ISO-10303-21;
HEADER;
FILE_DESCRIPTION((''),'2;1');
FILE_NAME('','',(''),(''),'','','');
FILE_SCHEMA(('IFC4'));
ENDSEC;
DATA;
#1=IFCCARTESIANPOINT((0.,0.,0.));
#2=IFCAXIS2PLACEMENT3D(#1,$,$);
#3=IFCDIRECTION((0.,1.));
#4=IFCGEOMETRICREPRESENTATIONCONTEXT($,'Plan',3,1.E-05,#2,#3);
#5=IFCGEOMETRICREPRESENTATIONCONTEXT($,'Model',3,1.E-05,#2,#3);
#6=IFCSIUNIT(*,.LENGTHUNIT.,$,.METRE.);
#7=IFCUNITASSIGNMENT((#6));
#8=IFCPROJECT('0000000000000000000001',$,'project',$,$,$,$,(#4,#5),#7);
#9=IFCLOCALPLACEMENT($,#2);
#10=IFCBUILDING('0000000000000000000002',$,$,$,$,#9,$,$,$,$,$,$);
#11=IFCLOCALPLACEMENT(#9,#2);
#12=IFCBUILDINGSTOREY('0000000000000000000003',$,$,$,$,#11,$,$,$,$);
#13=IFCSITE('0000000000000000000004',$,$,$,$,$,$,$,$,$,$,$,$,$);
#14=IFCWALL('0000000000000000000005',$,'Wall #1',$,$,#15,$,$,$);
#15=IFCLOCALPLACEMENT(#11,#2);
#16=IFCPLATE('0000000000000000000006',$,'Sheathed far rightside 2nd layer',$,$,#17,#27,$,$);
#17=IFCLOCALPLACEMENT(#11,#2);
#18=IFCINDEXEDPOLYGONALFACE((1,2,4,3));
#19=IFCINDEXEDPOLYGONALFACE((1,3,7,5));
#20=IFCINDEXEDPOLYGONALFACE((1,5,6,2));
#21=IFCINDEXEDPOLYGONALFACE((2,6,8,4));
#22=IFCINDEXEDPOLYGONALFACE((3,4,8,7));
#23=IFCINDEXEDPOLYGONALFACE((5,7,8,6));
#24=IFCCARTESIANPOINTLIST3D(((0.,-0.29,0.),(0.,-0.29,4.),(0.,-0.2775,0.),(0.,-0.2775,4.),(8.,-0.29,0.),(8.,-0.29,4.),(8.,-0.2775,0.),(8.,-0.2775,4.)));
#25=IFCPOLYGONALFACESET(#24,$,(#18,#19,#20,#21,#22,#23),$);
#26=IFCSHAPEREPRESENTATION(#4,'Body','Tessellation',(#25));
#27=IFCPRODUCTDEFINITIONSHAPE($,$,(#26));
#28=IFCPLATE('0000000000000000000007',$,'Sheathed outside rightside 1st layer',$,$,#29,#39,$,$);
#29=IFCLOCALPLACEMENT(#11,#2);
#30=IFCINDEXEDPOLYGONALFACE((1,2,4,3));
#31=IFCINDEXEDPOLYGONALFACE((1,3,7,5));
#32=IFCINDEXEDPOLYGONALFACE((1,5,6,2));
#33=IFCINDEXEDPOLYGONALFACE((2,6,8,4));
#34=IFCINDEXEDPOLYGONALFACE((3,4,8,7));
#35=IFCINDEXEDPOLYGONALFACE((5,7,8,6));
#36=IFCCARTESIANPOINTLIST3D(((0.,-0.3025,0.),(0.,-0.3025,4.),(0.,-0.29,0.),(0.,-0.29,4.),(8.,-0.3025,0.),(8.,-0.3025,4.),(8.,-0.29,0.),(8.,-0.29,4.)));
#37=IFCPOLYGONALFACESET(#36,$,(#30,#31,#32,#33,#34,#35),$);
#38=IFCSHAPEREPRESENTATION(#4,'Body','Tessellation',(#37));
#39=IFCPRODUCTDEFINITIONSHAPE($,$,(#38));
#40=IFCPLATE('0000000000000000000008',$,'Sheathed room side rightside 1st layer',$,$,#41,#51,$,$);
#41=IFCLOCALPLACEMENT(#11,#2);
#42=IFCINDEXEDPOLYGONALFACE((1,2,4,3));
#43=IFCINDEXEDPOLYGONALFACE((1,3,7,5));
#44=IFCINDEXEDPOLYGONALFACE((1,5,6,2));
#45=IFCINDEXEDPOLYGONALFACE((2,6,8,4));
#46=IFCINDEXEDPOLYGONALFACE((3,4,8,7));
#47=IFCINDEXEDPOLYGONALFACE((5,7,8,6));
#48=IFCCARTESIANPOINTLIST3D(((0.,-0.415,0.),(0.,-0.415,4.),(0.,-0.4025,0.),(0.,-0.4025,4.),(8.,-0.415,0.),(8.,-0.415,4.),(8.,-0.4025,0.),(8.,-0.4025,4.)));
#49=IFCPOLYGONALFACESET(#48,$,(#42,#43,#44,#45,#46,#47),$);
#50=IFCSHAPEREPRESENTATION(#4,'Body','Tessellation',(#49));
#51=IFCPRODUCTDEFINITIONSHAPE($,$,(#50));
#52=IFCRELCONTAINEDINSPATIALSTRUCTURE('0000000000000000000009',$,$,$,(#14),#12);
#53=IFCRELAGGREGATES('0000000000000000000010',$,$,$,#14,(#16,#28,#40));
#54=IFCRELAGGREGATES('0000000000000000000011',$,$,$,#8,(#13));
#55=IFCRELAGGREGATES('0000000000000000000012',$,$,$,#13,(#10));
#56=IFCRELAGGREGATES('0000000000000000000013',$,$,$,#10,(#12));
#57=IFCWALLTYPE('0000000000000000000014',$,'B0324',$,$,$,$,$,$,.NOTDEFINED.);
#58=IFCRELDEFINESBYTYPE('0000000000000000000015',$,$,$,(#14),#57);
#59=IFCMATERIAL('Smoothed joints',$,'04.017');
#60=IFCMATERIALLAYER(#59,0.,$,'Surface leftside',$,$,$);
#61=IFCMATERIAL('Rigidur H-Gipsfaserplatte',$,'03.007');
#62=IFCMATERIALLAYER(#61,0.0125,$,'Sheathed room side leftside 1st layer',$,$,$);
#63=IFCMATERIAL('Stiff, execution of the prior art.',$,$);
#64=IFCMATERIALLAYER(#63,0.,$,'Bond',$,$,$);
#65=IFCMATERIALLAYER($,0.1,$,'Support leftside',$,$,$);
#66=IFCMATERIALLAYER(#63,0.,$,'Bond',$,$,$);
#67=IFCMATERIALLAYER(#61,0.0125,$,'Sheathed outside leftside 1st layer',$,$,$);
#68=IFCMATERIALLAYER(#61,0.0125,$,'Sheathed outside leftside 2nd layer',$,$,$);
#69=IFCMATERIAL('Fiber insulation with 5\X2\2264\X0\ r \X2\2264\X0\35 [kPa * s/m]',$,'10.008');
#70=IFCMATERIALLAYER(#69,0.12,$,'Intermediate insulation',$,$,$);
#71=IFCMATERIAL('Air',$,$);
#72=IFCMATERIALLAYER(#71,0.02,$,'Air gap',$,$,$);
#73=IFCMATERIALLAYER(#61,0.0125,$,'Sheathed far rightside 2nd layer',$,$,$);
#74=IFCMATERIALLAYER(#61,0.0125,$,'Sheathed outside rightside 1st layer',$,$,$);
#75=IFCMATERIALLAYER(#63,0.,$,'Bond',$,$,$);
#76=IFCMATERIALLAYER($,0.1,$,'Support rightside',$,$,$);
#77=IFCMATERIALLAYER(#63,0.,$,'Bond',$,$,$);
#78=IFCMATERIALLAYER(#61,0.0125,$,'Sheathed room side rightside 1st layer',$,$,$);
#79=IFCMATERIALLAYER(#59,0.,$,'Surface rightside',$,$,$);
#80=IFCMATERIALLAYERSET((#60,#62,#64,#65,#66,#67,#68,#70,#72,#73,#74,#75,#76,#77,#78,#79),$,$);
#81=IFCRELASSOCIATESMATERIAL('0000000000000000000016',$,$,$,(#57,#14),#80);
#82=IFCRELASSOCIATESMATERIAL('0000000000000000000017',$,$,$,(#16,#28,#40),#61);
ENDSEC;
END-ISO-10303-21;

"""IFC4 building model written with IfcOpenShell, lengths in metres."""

from ifc_helpers import new_model, si_unit, direction, frame, frame_2d, origin, place, context, project, spatial, rectangle, extrude, material, layer, layer_set, type_object, element, aggregate, save


model = new_model("IFC4")

# Units and contexts
plan_context = context("Plan", 3, precision=1e-05, world=origin(), true_north=direction((0.0, 1.0)))
model_context = context("Model", 3, precision=1e-05, world=origin(), true_north=direction((0.0, 1.0)))
ifc_project = project(units=[si_unit("LENGTHUNIT", "METRE")], contexts=[plan_context, model_context])

# Site, building, storey
site = spatial("IfcSite", under=ifc_project)
building_placement = place(None, origin())
building = spatial("IfcBuilding", under=site, at=building_placement)
storey_placement = place(building_placement, origin())
storey = spatial("IfcBuildingStorey", under=building, at=storey_placement)

# Wall, plates
ifc_material_1 = material(Name="Smoothed joints", Category="04.017")
ifc_layer_1 = layer(ifc_material_1, 0.0, Name="Surface leftside")
ifc_material_2 = material(Name="Rigidur H-Gipsfaserplatte", Category="03.007")
ifc_layer_2 = layer(ifc_material_2, 0.0125, Name="Sheathed room side leftside 1st layer")
ifc_material_3 = material(Name="Stiff, execution of the prior art.")
ifc_layer_3 = layer(ifc_material_3, 0.0, Name="Bond")
ifc_layer_4 = layer(None, 0.1, Name="Support leftside")
ifc_layer_5 = layer(ifc_material_3, 0.0, Name="Bond")
ifc_layer_6 = layer(ifc_material_2, 0.0125, Name="Sheathed outside leftside 1st layer")
ifc_layer_7 = layer(ifc_material_2, 0.0125, Name="Sheathed outside leftside 2nd layer")
ifc_material_4 = material(Name="Fiber insulation with 5≤ r ≤35 [kPa * s/m]", Category="10.008")
ifc_layer_8 = layer(ifc_material_4, 0.12, Name="Intermediate insulation")
ifc_material_5 = material(Name="Air")
ifc_layer_9 = layer(ifc_material_5, 0.02, Name="Air gap")
ifc_layer_10 = layer(ifc_material_2, 0.0125, Name="Sheathed far rightside 2nd layer")
ifc_layer_11 = layer(ifc_material_2, 0.0125, Name="Sheathed outside rightside 1st layer")
ifc_layer_12 = layer(ifc_material_3, 0.0, Name="Bond")
ifc_layer_13 = layer(None, 0.1, Name="Support rightside")
ifc_layer_14 = layer(ifc_material_3, 0.0, Name="Bond")
ifc_layer_15 = layer(ifc_material_2, 0.0125, Name="Sheathed room side rightside 1st layer")
ifc_layer_16 = layer(ifc_material_1, 0.0, Name="Surface rightside")
ifc_layer_set = layer_set([ifc_layer_1, ifc_layer_2, ifc_layer_3, ifc_layer_4, ifc_layer_5, ifc_layer_6, ifc_layer_7, ifc_layer_8, ifc_layer_9, ifc_layer_10, ifc_layer_11, ifc_layer_12, ifc_layer_13, ifc_layer_14, ifc_layer_15, ifc_layer_16])
wall_type = type_object("IfcWallType", Name="B0324", PredefinedType="NOTDEFINED", material=ifc_layer_set)
wall_placement = place(None, frame((0.0, 0.0, 0.0), z_axis=(0.0, -1.0, 0.0), x_axis=(1.0, 0.0, 0.0)))
wall = element("IfcWall", 1, at=wall_placement, inside=storey, type_object=wall_type, material=ifc_layer_set, Name="Wall #1")
plate_1_placement = place(wall_placement, origin())
plate_1 = element("IfcPlate", 2, at=plate_1_placement, material=ifc_material_2, Name="Sheathed far rightside 2nd layer", context=plan_context, shape_type="SweptSolid", body=[
    extrude(rectangle(XDim=8.0, YDim=4.0, at=frame_2d((4.0, 2.0), x_axis=(1.0, 0.0))), frame((0.0, 0.0, 0.2775), z_axis=(0.0, 0.0, 1.0), x_axis=(1.0, 0.0, 0.0)), (0.0, 0.0, 1.0), 0.0125),
])
plate_2_placement = place(wall_placement, origin())
plate_2 = element("IfcPlate", 3, at=plate_2_placement, material=ifc_material_2, Name="Sheathed outside rightside 1st layer", context=plan_context, shape_type="SweptSolid", body=[
    extrude(rectangle(XDim=8.0, YDim=4.0, at=frame_2d((4.0, 2.0), x_axis=(1.0, 0.0))), frame((0.0, 0.0, 0.29), z_axis=(0.0, 0.0, 1.0), x_axis=(1.0, 0.0, 0.0)), (0.0, 0.0, 1.0), 0.0125),
])
plate_3_placement = place(wall_placement, origin())
plate_3 = element("IfcPlate", 4, at=plate_3_placement, material=ifc_material_2, Name="Sheathed room side rightside 1st layer", context=plan_context, shape_type="SweptSolid", body=[
    extrude(rectangle(XDim=8.0, YDim=4.0, at=frame_2d((4.0, 2.0), x_axis=(1.0, 0.0))), frame((0.0, 0.0, 0.4025), z_axis=(0.0, 0.0, 1.0), x_axis=(1.0, 0.0, 0.0)), (0.0, 0.0, 1.0), 0.0125),
])
aggregate(wall, [plate_1, plate_2, plate_3])

save(model, "model.ifc")
